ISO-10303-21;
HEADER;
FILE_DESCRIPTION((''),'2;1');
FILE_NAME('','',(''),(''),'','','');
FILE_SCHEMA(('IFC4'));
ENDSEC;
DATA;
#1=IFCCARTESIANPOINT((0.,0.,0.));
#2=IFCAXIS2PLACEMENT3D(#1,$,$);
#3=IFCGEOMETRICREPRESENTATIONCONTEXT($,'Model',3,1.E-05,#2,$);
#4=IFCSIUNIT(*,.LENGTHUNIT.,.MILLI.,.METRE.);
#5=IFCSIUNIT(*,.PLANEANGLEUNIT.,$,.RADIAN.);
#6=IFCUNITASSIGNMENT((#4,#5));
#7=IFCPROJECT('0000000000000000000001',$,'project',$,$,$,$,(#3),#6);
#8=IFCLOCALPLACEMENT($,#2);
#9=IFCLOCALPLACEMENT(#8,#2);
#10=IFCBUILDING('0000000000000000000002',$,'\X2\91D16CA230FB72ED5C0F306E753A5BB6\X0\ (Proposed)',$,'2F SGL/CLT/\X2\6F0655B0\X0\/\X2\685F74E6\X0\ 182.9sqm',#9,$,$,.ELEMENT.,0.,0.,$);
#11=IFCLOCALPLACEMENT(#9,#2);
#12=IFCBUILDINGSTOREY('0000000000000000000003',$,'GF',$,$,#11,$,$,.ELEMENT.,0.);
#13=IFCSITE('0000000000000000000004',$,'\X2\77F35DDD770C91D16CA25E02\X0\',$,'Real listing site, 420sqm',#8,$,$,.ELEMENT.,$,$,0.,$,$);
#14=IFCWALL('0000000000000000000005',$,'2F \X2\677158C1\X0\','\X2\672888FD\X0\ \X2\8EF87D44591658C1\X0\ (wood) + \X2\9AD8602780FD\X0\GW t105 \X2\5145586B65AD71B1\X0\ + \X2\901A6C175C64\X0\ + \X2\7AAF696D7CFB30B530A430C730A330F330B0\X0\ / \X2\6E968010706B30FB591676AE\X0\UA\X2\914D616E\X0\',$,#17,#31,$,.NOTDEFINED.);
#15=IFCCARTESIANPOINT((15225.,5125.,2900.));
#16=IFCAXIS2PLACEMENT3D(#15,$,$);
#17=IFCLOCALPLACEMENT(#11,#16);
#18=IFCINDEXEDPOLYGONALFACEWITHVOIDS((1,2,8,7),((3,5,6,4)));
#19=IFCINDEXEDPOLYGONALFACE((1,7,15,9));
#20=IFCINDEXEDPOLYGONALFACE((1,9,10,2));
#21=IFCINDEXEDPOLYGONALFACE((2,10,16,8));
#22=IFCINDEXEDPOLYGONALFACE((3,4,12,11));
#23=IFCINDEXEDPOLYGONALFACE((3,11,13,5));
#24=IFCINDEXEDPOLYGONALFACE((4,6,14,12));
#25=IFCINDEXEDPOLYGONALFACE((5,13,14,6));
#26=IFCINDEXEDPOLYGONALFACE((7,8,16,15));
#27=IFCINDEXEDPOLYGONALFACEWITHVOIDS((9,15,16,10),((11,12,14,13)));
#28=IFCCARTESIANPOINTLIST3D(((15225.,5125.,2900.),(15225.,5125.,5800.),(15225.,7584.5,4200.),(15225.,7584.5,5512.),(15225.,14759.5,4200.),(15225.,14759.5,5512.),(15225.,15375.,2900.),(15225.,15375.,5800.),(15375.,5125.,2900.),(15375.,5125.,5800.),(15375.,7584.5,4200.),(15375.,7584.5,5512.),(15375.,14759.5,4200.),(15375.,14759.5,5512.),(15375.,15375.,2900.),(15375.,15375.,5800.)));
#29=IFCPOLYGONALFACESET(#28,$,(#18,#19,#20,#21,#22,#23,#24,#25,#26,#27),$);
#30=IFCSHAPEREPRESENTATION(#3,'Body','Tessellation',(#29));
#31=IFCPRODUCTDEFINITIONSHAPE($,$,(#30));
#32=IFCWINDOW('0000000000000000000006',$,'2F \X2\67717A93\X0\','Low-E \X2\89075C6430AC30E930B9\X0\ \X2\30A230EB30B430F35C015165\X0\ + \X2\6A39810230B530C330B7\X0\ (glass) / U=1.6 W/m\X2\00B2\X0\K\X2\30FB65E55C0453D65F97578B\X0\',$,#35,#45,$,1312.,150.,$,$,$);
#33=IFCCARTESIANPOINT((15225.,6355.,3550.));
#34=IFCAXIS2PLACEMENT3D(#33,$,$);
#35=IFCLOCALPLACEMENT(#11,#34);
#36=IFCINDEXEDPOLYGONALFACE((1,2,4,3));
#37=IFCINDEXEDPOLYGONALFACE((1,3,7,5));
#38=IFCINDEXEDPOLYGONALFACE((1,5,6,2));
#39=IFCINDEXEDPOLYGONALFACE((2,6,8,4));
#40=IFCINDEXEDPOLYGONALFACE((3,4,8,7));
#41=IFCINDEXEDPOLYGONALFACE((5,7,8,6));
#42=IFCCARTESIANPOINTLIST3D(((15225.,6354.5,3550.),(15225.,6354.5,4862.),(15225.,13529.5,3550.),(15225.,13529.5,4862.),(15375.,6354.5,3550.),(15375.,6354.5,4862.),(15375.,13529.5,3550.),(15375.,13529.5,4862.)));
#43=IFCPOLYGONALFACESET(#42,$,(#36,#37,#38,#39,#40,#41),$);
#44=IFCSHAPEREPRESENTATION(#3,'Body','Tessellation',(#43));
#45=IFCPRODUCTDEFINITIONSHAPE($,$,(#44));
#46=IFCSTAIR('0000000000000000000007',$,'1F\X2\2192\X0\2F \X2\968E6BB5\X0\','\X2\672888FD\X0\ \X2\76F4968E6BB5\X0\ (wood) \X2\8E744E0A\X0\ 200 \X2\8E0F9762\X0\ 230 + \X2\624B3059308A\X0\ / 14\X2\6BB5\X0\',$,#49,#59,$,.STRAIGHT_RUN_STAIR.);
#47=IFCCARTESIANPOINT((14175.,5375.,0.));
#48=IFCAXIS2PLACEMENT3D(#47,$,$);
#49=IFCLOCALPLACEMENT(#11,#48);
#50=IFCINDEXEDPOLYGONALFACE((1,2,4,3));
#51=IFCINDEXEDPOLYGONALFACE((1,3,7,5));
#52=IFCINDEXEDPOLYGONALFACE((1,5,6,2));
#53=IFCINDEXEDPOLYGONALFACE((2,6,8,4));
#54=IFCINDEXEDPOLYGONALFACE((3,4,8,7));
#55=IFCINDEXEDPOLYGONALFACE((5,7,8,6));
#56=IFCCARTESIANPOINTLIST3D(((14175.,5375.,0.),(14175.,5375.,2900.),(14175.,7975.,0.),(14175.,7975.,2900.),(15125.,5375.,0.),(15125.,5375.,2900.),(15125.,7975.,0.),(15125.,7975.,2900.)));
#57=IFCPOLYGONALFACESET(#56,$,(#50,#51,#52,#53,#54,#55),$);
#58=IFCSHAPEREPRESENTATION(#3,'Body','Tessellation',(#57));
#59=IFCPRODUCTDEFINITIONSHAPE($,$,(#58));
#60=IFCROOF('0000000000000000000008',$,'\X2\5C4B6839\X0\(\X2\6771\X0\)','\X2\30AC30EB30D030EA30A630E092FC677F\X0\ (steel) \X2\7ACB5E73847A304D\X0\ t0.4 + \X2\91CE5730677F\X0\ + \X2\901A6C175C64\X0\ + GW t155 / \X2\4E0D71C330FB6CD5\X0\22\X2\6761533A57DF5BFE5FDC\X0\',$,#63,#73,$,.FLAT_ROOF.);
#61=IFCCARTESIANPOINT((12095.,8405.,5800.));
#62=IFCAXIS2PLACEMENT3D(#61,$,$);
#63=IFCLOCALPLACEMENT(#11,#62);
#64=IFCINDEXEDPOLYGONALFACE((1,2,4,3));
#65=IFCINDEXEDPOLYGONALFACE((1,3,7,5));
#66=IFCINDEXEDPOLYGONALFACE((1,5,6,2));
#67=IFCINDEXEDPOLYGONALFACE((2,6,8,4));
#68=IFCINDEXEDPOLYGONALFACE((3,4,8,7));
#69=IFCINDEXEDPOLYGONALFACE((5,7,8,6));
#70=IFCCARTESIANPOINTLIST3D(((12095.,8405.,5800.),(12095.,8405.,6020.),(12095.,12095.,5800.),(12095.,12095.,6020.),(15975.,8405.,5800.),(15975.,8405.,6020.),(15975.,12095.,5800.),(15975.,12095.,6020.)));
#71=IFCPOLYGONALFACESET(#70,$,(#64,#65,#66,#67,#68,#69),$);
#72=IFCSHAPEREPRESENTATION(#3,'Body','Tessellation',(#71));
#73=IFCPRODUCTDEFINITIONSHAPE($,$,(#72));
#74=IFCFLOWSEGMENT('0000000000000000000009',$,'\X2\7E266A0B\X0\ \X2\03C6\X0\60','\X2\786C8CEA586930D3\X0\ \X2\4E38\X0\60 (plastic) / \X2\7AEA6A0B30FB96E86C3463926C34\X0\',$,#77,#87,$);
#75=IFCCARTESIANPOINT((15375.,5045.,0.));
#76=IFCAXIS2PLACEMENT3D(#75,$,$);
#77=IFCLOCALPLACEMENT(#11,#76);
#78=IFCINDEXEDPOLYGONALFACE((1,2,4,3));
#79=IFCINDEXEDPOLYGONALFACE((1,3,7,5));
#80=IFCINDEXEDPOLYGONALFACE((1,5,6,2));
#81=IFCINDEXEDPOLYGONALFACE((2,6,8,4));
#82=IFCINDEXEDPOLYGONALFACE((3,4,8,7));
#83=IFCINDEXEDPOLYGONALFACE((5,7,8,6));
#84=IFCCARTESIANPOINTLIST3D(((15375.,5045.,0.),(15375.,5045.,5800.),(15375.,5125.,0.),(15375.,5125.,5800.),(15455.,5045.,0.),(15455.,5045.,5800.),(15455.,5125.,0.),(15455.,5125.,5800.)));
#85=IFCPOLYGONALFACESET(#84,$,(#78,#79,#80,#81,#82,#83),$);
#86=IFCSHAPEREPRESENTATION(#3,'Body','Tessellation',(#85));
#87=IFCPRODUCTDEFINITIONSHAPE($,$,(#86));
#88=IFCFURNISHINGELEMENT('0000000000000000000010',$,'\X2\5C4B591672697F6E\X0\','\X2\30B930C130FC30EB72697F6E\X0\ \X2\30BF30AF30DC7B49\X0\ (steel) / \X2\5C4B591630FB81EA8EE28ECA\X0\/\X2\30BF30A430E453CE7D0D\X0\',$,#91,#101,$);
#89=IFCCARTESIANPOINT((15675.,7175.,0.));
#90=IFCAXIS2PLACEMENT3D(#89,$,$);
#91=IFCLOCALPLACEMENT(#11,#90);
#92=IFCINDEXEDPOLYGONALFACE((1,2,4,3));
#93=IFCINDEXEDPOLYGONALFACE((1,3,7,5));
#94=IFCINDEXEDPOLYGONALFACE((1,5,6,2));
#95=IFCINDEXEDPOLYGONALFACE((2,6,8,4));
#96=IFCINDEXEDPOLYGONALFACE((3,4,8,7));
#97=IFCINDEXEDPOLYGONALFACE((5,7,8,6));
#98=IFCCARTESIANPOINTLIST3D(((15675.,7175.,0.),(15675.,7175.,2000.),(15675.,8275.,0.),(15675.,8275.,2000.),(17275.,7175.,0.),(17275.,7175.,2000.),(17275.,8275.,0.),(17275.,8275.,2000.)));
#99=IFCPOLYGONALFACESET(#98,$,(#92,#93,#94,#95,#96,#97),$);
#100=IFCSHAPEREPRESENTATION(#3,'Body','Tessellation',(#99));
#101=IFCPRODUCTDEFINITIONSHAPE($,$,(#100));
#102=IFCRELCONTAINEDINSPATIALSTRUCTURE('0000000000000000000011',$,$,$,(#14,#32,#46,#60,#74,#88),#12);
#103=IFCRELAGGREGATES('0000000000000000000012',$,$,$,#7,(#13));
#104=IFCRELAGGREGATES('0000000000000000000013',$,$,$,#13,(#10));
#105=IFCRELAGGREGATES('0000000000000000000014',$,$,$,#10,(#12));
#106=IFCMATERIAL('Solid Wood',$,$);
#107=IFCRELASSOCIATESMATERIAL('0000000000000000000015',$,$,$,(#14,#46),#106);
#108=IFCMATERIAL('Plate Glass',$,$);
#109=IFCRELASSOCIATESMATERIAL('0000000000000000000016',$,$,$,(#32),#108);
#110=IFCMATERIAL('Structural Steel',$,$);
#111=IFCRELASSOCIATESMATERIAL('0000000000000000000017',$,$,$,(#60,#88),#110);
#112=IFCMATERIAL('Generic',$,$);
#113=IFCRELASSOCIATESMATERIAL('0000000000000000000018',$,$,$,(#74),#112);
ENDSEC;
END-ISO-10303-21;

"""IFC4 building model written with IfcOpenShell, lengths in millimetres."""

from ifc_helpers import new_model, si_unit, frame, frame_2d, origin, place, context, project, spatial, rectangle, extrude, material, element, fill, save


model = new_model("IFC4")

# Units and contexts
model_context = context("Model", 3, precision=1e-05, world=origin())
ifc_project = project(units=[si_unit("LENGTHUNIT", "METRE", prefix="MILLI"), si_unit("PLANEANGLEUNIT", "RADIAN")], contexts=[model_context])

# Site, building, storey
site_placement = place(None, origin())
site = spatial("IfcSite", under=ifc_project, at=site_placement, Name="石川県金沢市", ObjectType="Real listing site, 420sqm", CompositionType="ELEMENT", RefElevation=0.0)
building_placement = place(site_placement, origin())
building = spatial("IfcBuilding", under=site, at=building_placement, Name="金沢・狭小の町家 (Proposed)", ObjectType="2F SGL/CLT/漆喰/桟瓦 182.9sqm", CompositionType="ELEMENT", ElevationOfRefHeight=0.0, ElevationOfTerrain=0.0)
storey_placement = place(building_placement, origin())
storey = spatial("IfcBuildingStorey", under=building, at=storey_placement, Name="GF", CompositionType="ELEMENT", Elevation=0.0)

# Shared definitions
ifc_material_1 = material(Name="Solid Wood")

# Wall, opening, window
ifc_material_2 = material(Name="Plate Glass")
wall_1_placement = place(storey_placement, frame((15225.0, 5125.0, 2900.0)))
wall_1 = element("IfcWall", 1, at=wall_1_placement, inside=storey, material=ifc_material_1, Name="2F 東壁", Description="木製 軸組外壁 (wood) + 高性能GW t105 充填断熱 + 通気層 + 窯業系サイディング / 準耐火・外皮UA配慮", PredefinedType="NOTDEFINED", context=model_context, shape_type="SweptSolid", body=[
    extrude(rectangle(XDim=150.0, YDim=10250.0, at=frame_2d((75.0, 5125.0))), frame((15225.0, 5125.0, 2900.0)), (0.0, 0.0, 1.0), 2900.0),
])
opening_1_placement = place(storey_placement, frame((15225.0, 6355.0, 3550.0)))
opening_1 = element("IfcOpeningElement", 2, at=opening_1_placement, cuts=wall_1, PredefinedType="NOTDEFINED", context=model_context, shape_type="SweptSolid", body=[
    extrude(rectangle(XDim=150.0, YDim=7175.0, at=frame_2d((75.0, 3587.0))), frame((15225.0, 6355.0, 3550.0)), (0.0, 0.0, 1.0), 1312.0),
])
window_1_placement = place(storey_placement, frame((15225.0, 6355.0, 3550.0)))
window_1 = element("IfcWindow", 3, at=window_1_placement, inside=storey, material=ifc_material_2, Name="2F 東窓", Description="Low-E 複層ガラス アルゴン封入 + 樹脂サッシ (glass) / U=1.6 W/m²K・日射取得型", OverallHeight=1312.0, OverallWidth=150.0, context=model_context, shape_type="SweptSolid", body=[
    extrude(rectangle(XDim=150.0, YDim=7175.0, at=frame_2d((75.0, 3587.0))), frame((15225.0, 6355.0, 3550.0)), (0.0, 0.0, 1.0), 1312.0),
])
fill(opening_1, window_1)

# Stair
stair_placement = place(storey_placement, frame((14175.0, 5375.0, 0.0)))
element("IfcStair", 4, at=stair_placement, inside=storey, material=ifc_material_1, Name="1F→2F 階段", Description="木製 直階段 (wood) 蹴上 200 踏面 230 + 手すり / 14段", PredefinedType="STRAIGHT_RUN_STAIR", context=model_context, shape_type="SweptSolid", body=[
    extrude(rectangle(XDim=950.0, YDim=2600.0, at=frame_2d((475.0, 1300.0))), frame((14175.0, 5375.0, 0.0)), (0.0, 0.0, 1.0), 2900.0),
])

# Roof
ifc_material_3 = material(Name="Structural Steel")
roof_placement = place(storey_placement, frame((12095.0, 8405.0, 5800.0)))
element("IfcRoof", 5, at=roof_placement, inside=storey, material=ifc_material_3, Name="屋根(東)", Description="ガルバリウム鋼板 (steel) 立平葺き t0.4 + 野地板 + 通気層 + GW t155 / 不燃・法22条区域対応", PredefinedType="FLAT_ROOF", context=model_context, shape_type="SweptSolid", body=[
    extrude(rectangle(XDim=3880.0, YDim=3690.0, at=frame_2d((1940.0, 1845.0))), frame((12095.0, 8405.0, 5800.0)), (0.0, 0.0, 1.0), 220.0),
])

# Flow segment
ifc_material_4 = material(Name="Generic")
flow_segment_placement = place(storey_placement, frame((15375.0, 5045.0, 0.0)))
element("IfcFlowSegment", 6, at=flow_segment_placement, inside=storey, material=ifc_material_4, Name="縦樋 φ60", Description="硬質塩ビ 丸60 (plastic) / 竪樋・雨水排水", context=model_context, shape_type="SweptSolid", body=[
    extrude(rectangle(XDim=80.0, YDim=80.0, at=frame_2d((40.0, 40.0))), frame((15375.0, 5045.0, 0.0)), (0.0, 0.0, 1.0), 5800.0),
])

# Furnishing element
furnishing_placement = place(storey_placement, frame((15675.0, 7175.0, 0.0)))
element("IfcFurnishingElement", 7, at=furnishing_placement, inside=storey, material=ifc_material_3, Name="屋外物置", Description="スチール物置 タクボ等 (steel) / 屋外・自転車/タイヤ収納", context=model_context, shape_type="SweptSolid", body=[
    extrude(rectangle(XDim=1600.0, YDim=1100.0, at=frame_2d((800.0, 550.0))), frame((15675.0, 7175.0, 0.0)), (0.0, 0.0, 1.0), 2000.0),
])

save(model, "model.ifc")
